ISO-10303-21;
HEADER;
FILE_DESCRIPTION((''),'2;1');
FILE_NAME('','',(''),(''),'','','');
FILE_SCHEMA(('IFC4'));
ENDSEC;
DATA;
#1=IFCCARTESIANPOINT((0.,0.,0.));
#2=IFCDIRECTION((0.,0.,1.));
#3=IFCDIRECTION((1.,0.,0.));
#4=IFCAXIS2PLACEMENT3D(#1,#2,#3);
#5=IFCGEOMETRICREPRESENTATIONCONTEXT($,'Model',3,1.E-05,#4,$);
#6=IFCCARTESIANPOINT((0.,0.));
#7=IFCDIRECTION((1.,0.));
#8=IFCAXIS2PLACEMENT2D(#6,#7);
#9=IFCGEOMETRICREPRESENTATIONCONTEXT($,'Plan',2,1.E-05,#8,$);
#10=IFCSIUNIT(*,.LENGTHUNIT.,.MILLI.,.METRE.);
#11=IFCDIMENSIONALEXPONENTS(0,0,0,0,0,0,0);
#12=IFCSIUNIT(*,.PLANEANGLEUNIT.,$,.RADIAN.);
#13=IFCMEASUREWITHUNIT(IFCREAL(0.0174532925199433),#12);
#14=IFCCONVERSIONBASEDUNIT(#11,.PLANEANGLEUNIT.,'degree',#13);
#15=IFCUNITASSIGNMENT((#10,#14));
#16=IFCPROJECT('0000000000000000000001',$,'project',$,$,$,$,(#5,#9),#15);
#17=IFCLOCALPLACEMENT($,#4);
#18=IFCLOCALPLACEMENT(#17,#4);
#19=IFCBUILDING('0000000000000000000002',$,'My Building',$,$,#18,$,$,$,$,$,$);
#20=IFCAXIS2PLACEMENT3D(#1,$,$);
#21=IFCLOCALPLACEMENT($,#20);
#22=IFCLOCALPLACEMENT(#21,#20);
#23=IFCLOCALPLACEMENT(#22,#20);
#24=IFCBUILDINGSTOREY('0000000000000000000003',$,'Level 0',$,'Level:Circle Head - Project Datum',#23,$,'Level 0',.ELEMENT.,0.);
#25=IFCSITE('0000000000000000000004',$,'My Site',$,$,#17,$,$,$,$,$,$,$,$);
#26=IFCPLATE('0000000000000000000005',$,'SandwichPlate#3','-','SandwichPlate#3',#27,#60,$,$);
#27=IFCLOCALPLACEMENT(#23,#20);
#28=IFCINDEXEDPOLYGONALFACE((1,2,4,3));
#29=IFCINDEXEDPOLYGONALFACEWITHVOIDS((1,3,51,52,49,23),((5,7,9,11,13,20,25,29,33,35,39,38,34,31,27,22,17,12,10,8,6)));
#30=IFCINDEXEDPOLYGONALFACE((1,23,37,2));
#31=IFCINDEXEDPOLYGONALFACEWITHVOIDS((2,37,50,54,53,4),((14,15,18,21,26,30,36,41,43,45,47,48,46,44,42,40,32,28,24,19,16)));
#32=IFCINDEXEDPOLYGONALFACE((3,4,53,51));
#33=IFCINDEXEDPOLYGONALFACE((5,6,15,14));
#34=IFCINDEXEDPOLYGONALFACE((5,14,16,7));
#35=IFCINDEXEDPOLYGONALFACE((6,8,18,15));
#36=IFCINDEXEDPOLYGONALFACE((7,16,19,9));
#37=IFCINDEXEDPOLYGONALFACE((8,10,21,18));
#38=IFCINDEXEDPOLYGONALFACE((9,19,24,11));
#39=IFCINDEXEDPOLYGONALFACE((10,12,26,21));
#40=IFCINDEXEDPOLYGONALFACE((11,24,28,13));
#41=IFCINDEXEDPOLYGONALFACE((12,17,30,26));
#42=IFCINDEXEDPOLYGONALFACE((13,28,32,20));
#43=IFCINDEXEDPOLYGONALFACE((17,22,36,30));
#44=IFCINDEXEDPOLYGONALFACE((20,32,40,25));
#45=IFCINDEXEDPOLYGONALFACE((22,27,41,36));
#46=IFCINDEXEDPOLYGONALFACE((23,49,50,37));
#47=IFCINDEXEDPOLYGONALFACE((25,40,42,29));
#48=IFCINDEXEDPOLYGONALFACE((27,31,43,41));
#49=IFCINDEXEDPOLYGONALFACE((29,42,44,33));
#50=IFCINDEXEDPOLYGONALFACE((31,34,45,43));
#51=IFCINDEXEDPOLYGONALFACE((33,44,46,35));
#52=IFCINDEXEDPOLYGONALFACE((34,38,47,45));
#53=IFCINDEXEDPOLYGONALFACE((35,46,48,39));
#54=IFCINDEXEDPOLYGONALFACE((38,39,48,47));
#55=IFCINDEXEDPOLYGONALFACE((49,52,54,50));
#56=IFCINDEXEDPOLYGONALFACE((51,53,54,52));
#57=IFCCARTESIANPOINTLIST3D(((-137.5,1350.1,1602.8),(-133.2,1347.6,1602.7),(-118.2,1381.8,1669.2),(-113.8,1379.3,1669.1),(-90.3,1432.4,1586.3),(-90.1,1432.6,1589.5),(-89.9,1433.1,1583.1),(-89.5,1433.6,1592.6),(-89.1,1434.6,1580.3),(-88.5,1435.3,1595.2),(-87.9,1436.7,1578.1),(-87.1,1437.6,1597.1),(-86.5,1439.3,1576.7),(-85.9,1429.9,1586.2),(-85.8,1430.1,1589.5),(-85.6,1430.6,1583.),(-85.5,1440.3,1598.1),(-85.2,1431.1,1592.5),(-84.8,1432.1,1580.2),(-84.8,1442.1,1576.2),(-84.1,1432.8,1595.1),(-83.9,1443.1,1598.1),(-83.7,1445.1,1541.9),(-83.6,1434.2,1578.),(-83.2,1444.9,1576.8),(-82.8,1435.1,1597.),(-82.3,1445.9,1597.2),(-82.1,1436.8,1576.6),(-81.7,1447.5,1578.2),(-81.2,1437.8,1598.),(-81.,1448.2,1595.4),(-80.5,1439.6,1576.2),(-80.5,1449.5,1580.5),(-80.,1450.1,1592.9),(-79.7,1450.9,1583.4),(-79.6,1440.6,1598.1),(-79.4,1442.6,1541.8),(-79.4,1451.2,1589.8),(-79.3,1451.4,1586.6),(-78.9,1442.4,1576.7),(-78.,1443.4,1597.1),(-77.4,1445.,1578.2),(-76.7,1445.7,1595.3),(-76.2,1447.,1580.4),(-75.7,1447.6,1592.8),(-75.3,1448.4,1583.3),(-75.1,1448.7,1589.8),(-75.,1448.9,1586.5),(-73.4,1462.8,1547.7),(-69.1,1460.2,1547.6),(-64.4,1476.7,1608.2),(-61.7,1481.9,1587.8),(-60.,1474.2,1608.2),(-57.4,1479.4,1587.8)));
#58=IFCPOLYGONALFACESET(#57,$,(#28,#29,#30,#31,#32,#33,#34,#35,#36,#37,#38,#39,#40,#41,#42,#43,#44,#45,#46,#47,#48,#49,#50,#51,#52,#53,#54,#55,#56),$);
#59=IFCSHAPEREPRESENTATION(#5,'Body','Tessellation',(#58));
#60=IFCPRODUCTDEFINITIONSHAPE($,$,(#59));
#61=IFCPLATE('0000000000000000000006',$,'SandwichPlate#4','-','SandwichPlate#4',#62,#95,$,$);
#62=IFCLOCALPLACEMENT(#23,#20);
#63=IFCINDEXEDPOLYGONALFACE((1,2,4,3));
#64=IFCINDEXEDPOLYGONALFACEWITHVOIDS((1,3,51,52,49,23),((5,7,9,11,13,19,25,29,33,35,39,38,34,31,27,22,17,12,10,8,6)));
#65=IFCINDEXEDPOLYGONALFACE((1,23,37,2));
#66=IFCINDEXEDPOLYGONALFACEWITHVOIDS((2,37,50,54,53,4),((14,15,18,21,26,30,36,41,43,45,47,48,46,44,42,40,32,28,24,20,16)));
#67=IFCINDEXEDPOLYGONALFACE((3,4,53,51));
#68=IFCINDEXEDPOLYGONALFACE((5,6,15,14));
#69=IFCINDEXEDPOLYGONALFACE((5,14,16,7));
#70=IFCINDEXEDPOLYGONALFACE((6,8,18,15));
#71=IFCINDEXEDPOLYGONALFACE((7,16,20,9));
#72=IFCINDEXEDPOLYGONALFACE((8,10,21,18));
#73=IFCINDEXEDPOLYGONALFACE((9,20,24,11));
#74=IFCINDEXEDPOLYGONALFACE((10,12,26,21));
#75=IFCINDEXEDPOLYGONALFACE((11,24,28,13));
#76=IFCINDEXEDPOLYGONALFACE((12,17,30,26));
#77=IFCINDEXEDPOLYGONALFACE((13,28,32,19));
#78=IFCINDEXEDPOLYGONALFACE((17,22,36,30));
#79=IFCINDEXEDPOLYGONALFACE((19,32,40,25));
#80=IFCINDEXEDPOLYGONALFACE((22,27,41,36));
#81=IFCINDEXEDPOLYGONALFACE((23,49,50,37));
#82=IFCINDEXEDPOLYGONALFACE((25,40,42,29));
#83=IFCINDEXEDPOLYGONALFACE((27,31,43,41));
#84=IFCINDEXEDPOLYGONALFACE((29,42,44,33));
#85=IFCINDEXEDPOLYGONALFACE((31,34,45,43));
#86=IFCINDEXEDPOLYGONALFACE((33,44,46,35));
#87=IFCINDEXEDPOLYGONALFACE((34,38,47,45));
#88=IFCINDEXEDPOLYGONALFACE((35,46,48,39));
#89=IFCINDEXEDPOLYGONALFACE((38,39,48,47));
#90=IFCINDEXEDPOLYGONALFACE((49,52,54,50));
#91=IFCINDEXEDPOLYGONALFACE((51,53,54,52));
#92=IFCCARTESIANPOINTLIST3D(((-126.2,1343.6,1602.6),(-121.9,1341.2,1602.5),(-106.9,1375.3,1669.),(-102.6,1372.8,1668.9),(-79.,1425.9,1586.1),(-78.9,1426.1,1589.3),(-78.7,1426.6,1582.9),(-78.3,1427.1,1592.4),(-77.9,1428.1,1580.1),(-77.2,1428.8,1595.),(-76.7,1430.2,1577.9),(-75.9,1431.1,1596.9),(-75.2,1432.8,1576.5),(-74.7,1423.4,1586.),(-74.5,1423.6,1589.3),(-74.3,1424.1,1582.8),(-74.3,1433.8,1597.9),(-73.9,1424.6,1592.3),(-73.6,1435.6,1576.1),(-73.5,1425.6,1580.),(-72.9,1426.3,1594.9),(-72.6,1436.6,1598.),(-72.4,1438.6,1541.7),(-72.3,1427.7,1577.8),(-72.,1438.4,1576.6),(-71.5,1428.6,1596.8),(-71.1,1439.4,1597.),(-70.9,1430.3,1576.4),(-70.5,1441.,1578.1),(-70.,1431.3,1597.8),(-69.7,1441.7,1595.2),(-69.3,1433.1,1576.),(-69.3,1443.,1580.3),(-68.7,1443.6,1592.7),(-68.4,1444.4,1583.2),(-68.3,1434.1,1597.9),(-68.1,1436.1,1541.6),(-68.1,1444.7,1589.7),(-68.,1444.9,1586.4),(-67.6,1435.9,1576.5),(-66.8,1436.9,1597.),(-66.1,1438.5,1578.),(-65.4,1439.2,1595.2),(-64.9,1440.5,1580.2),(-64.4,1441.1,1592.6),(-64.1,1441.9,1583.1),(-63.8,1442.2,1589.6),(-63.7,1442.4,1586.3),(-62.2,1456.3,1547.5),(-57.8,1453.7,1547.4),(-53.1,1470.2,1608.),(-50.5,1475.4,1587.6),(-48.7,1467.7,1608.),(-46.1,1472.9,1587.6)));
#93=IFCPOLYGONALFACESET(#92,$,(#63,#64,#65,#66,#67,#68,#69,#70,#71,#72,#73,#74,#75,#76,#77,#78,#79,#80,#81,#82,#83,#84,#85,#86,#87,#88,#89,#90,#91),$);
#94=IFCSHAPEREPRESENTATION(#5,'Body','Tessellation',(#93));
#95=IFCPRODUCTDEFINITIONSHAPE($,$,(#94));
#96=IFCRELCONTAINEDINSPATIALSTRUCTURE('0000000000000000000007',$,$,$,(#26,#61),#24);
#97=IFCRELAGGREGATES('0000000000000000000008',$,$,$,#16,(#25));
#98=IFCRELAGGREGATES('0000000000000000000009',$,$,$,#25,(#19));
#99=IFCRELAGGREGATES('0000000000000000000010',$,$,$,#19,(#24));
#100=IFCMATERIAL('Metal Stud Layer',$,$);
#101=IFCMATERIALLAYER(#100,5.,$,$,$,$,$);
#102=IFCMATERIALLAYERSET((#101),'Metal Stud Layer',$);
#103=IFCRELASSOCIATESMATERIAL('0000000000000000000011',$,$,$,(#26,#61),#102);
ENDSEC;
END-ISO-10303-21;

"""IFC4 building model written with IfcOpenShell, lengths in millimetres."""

from ifc_helpers import new_model, entity, si_unit, converted_unit, frame, origin, origin_with_axes, origin_2d_with_axis, place, context, project, spatial, polyline, circle, outline, extrude, material, layer, layer_set, element, save


model = new_model("IFC4")

# Units and contexts
model_context = context("Model", 3, precision=1e-05, world=origin_with_axes())
plan_context = context("Plan", 2, precision=1e-05, world=origin_2d_with_axis())
ifc_project = project(units=[si_unit("LENGTHUNIT", "METRE", prefix="MILLI"), converted_unit("PLANEANGLEUNIT", "degree", entity("IfcReal", 0.0174532925199433), si_unit("PLANEANGLEUNIT", "RADIAN"), dimensions=[0, 0, 0, 0, 0, 0, 0])], contexts=[model_context, plan_context])

# Site, building, storey
site_placement = place(None, origin_with_axes())
site = spatial("IfcSite", under=ifc_project, at=site_placement, Name="My Site")
building_placement = place(site_placement, origin_with_axes())
building = spatial("IfcBuilding", under=site, at=building_placement, Name="My Building")
placement_1 = place(None, origin())
placement_2 = place(placement_1, origin())
storey_placement = place(placement_2, origin())
storey = spatial("IfcBuildingStorey", under=building, at=storey_placement, Name="Level 0", ObjectType="Level:Circle Head - Project Datum", LongName="Level 0", CompositionType="ELEMENT", Elevation=0.0)

# Plates, openings
ifc_material = material(Name="Metal Stud Layer")
ifc_layer_1 = layer(ifc_material, 5.0)
ifc_layer_set_1 = layer_set([ifc_layer_1], Name="Metal Stud Layer")
plate_1_placement = place(storey_placement, frame((-77.2, 1456.5, 1534.6), z_axis=(0.865935, -0.499948, -0.014432), x_axis=(0.254617, 0.415806, 0.873084)))
plate_1 = element("IfcPlate", 1, at=plate_1_placement, inside=storey, material=ifc_layer_set_1, Name="SandwichPlate#3", Description="-", ObjectType="SandwichPlate#3", context=model_context, shape_type="SweptSolid", body=[
    extrude(outline(polyline([(0.0, 0.0), (76.0, 0.0), (76.0, 140.0), (0.0, 140.0), (0.0, 0.0)])), origin_with_axes(), (0.0, 0.0, 1.0), 5.0),
])
opening_1_placement = place(plate_1_placement, frame((0.0, 0.0, 0.0), z_axis=(0.0, 0.0, 1.0), x_axis=(1.0, 0.0, 0.0)))
element("IfcOpeningElement", 2, at=opening_1_placement, cuts=plate_1, ObjectType="Opening", context=model_context, shape_type="SweptSolid", body=[
    extrude(outline(polyline([(0.0, 0.0), (15.0, 0.0), (0.0, 15.0), (0.0, 0.0)])), origin(), (0.0, 0.0, 1.0), 5.0),
])
opening_2_placement = place(plate_1_placement, frame((0.0, 0.0, 0.0), z_axis=(0.0, 0.0, 1.0), x_axis=(1.0, 0.0, 0.0)))
element("IfcOpeningElement", 3, at=opening_2_placement, cuts=plate_1, ObjectType="Opening", context=model_context, shape_type="SweptSolid", body=[
    extrude(outline(polyline([(76.0, 0.0), (76.0, 15.0), (61.0, 0.0), (76.0, 0.0)])), origin(), (0.0, 0.0, 1.0), 5.0),
])
opening_3_placement = place(plate_1_placement, frame((38.0, 40.0, -0.5), z_axis=(0.0, 0.0, 1.0), x_axis=(0.0, 1.0, 0.0)))
element("IfcOpeningElement", 4, at=opening_3_placement, cuts=plate_1, ObjectType="Opening", context=model_context, shape_type="SweptSolid", body=[
    extrude(circle(Radius=11.0, at=origin_2d_with_axis()), origin(), (0.0, 0.0, 1.0), 6.0),
])
plate_2_placement = place(storey_placement, frame((-66.0, 1450.0, 1534.4), z_axis=(0.865935, -0.499948, -0.014432), x_axis=(0.254617, 0.415806, 0.873084)))
plate_2 = element("IfcPlate", 5, at=plate_2_placement, inside=storey, material=ifc_layer_set_1, Name="SandwichPlate#4", Description="-", ObjectType="SandwichPlate#4", context=model_context, shape_type="SweptSolid", body=[
    extrude(outline(polyline([(0.0, 0.0), (76.0, 0.0), (76.0, 140.0), (0.0, 140.0), (0.0, 0.0)])), origin_with_axes(), (0.0, 0.0, 1.0), 5.0),
])
opening_4_placement = place(plate_2_placement, frame((0.0, 0.0, 0.0), z_axis=(0.0, 0.0, 1.0), x_axis=(1.0, 0.0, 0.0)))
element("IfcOpeningElement", 6, at=opening_4_placement, cuts=plate_2, ObjectType="Opening", context=model_context, shape_type="SweptSolid", body=[
    extrude(outline(polyline([(76.0, 0.0), (76.0, 15.0), (61.0, 0.0), (76.0, 0.0)])), origin(), (0.0, 0.0, 1.0), 5.0),
])
opening_5_placement = place(plate_2_placement, frame((38.0, 40.0, -0.5), z_axis=(0.0, 0.0, 1.0), x_axis=(0.0, 1.0, 0.0)))
element("IfcOpeningElement", 7, at=opening_5_placement, cuts=plate_2, ObjectType="Opening", context=model_context, shape_type="SweptSolid", body=[
    extrude(circle(Radius=11.0, at=origin_2d_with_axis()), origin(), (0.0, 0.0, 1.0), 6.0),
])
opening_6_placement = place(plate_2_placement, frame((0.0, 0.0, 0.0), z_axis=(0.0, 0.0, 1.0), x_axis=(1.0, 0.0, 0.0)))
element("IfcOpeningElement", 8, at=opening_6_placement, cuts=plate_2, ObjectType="Opening", context=model_context, shape_type="SweptSolid", body=[
    extrude(outline(polyline([(0.0, 0.0), (15.0, 0.0), (0.0, 15.0), (0.0, 0.0)])), origin(), (0.0, 0.0, 1.0), 5.0),
])

save(model, "model.ifc")
